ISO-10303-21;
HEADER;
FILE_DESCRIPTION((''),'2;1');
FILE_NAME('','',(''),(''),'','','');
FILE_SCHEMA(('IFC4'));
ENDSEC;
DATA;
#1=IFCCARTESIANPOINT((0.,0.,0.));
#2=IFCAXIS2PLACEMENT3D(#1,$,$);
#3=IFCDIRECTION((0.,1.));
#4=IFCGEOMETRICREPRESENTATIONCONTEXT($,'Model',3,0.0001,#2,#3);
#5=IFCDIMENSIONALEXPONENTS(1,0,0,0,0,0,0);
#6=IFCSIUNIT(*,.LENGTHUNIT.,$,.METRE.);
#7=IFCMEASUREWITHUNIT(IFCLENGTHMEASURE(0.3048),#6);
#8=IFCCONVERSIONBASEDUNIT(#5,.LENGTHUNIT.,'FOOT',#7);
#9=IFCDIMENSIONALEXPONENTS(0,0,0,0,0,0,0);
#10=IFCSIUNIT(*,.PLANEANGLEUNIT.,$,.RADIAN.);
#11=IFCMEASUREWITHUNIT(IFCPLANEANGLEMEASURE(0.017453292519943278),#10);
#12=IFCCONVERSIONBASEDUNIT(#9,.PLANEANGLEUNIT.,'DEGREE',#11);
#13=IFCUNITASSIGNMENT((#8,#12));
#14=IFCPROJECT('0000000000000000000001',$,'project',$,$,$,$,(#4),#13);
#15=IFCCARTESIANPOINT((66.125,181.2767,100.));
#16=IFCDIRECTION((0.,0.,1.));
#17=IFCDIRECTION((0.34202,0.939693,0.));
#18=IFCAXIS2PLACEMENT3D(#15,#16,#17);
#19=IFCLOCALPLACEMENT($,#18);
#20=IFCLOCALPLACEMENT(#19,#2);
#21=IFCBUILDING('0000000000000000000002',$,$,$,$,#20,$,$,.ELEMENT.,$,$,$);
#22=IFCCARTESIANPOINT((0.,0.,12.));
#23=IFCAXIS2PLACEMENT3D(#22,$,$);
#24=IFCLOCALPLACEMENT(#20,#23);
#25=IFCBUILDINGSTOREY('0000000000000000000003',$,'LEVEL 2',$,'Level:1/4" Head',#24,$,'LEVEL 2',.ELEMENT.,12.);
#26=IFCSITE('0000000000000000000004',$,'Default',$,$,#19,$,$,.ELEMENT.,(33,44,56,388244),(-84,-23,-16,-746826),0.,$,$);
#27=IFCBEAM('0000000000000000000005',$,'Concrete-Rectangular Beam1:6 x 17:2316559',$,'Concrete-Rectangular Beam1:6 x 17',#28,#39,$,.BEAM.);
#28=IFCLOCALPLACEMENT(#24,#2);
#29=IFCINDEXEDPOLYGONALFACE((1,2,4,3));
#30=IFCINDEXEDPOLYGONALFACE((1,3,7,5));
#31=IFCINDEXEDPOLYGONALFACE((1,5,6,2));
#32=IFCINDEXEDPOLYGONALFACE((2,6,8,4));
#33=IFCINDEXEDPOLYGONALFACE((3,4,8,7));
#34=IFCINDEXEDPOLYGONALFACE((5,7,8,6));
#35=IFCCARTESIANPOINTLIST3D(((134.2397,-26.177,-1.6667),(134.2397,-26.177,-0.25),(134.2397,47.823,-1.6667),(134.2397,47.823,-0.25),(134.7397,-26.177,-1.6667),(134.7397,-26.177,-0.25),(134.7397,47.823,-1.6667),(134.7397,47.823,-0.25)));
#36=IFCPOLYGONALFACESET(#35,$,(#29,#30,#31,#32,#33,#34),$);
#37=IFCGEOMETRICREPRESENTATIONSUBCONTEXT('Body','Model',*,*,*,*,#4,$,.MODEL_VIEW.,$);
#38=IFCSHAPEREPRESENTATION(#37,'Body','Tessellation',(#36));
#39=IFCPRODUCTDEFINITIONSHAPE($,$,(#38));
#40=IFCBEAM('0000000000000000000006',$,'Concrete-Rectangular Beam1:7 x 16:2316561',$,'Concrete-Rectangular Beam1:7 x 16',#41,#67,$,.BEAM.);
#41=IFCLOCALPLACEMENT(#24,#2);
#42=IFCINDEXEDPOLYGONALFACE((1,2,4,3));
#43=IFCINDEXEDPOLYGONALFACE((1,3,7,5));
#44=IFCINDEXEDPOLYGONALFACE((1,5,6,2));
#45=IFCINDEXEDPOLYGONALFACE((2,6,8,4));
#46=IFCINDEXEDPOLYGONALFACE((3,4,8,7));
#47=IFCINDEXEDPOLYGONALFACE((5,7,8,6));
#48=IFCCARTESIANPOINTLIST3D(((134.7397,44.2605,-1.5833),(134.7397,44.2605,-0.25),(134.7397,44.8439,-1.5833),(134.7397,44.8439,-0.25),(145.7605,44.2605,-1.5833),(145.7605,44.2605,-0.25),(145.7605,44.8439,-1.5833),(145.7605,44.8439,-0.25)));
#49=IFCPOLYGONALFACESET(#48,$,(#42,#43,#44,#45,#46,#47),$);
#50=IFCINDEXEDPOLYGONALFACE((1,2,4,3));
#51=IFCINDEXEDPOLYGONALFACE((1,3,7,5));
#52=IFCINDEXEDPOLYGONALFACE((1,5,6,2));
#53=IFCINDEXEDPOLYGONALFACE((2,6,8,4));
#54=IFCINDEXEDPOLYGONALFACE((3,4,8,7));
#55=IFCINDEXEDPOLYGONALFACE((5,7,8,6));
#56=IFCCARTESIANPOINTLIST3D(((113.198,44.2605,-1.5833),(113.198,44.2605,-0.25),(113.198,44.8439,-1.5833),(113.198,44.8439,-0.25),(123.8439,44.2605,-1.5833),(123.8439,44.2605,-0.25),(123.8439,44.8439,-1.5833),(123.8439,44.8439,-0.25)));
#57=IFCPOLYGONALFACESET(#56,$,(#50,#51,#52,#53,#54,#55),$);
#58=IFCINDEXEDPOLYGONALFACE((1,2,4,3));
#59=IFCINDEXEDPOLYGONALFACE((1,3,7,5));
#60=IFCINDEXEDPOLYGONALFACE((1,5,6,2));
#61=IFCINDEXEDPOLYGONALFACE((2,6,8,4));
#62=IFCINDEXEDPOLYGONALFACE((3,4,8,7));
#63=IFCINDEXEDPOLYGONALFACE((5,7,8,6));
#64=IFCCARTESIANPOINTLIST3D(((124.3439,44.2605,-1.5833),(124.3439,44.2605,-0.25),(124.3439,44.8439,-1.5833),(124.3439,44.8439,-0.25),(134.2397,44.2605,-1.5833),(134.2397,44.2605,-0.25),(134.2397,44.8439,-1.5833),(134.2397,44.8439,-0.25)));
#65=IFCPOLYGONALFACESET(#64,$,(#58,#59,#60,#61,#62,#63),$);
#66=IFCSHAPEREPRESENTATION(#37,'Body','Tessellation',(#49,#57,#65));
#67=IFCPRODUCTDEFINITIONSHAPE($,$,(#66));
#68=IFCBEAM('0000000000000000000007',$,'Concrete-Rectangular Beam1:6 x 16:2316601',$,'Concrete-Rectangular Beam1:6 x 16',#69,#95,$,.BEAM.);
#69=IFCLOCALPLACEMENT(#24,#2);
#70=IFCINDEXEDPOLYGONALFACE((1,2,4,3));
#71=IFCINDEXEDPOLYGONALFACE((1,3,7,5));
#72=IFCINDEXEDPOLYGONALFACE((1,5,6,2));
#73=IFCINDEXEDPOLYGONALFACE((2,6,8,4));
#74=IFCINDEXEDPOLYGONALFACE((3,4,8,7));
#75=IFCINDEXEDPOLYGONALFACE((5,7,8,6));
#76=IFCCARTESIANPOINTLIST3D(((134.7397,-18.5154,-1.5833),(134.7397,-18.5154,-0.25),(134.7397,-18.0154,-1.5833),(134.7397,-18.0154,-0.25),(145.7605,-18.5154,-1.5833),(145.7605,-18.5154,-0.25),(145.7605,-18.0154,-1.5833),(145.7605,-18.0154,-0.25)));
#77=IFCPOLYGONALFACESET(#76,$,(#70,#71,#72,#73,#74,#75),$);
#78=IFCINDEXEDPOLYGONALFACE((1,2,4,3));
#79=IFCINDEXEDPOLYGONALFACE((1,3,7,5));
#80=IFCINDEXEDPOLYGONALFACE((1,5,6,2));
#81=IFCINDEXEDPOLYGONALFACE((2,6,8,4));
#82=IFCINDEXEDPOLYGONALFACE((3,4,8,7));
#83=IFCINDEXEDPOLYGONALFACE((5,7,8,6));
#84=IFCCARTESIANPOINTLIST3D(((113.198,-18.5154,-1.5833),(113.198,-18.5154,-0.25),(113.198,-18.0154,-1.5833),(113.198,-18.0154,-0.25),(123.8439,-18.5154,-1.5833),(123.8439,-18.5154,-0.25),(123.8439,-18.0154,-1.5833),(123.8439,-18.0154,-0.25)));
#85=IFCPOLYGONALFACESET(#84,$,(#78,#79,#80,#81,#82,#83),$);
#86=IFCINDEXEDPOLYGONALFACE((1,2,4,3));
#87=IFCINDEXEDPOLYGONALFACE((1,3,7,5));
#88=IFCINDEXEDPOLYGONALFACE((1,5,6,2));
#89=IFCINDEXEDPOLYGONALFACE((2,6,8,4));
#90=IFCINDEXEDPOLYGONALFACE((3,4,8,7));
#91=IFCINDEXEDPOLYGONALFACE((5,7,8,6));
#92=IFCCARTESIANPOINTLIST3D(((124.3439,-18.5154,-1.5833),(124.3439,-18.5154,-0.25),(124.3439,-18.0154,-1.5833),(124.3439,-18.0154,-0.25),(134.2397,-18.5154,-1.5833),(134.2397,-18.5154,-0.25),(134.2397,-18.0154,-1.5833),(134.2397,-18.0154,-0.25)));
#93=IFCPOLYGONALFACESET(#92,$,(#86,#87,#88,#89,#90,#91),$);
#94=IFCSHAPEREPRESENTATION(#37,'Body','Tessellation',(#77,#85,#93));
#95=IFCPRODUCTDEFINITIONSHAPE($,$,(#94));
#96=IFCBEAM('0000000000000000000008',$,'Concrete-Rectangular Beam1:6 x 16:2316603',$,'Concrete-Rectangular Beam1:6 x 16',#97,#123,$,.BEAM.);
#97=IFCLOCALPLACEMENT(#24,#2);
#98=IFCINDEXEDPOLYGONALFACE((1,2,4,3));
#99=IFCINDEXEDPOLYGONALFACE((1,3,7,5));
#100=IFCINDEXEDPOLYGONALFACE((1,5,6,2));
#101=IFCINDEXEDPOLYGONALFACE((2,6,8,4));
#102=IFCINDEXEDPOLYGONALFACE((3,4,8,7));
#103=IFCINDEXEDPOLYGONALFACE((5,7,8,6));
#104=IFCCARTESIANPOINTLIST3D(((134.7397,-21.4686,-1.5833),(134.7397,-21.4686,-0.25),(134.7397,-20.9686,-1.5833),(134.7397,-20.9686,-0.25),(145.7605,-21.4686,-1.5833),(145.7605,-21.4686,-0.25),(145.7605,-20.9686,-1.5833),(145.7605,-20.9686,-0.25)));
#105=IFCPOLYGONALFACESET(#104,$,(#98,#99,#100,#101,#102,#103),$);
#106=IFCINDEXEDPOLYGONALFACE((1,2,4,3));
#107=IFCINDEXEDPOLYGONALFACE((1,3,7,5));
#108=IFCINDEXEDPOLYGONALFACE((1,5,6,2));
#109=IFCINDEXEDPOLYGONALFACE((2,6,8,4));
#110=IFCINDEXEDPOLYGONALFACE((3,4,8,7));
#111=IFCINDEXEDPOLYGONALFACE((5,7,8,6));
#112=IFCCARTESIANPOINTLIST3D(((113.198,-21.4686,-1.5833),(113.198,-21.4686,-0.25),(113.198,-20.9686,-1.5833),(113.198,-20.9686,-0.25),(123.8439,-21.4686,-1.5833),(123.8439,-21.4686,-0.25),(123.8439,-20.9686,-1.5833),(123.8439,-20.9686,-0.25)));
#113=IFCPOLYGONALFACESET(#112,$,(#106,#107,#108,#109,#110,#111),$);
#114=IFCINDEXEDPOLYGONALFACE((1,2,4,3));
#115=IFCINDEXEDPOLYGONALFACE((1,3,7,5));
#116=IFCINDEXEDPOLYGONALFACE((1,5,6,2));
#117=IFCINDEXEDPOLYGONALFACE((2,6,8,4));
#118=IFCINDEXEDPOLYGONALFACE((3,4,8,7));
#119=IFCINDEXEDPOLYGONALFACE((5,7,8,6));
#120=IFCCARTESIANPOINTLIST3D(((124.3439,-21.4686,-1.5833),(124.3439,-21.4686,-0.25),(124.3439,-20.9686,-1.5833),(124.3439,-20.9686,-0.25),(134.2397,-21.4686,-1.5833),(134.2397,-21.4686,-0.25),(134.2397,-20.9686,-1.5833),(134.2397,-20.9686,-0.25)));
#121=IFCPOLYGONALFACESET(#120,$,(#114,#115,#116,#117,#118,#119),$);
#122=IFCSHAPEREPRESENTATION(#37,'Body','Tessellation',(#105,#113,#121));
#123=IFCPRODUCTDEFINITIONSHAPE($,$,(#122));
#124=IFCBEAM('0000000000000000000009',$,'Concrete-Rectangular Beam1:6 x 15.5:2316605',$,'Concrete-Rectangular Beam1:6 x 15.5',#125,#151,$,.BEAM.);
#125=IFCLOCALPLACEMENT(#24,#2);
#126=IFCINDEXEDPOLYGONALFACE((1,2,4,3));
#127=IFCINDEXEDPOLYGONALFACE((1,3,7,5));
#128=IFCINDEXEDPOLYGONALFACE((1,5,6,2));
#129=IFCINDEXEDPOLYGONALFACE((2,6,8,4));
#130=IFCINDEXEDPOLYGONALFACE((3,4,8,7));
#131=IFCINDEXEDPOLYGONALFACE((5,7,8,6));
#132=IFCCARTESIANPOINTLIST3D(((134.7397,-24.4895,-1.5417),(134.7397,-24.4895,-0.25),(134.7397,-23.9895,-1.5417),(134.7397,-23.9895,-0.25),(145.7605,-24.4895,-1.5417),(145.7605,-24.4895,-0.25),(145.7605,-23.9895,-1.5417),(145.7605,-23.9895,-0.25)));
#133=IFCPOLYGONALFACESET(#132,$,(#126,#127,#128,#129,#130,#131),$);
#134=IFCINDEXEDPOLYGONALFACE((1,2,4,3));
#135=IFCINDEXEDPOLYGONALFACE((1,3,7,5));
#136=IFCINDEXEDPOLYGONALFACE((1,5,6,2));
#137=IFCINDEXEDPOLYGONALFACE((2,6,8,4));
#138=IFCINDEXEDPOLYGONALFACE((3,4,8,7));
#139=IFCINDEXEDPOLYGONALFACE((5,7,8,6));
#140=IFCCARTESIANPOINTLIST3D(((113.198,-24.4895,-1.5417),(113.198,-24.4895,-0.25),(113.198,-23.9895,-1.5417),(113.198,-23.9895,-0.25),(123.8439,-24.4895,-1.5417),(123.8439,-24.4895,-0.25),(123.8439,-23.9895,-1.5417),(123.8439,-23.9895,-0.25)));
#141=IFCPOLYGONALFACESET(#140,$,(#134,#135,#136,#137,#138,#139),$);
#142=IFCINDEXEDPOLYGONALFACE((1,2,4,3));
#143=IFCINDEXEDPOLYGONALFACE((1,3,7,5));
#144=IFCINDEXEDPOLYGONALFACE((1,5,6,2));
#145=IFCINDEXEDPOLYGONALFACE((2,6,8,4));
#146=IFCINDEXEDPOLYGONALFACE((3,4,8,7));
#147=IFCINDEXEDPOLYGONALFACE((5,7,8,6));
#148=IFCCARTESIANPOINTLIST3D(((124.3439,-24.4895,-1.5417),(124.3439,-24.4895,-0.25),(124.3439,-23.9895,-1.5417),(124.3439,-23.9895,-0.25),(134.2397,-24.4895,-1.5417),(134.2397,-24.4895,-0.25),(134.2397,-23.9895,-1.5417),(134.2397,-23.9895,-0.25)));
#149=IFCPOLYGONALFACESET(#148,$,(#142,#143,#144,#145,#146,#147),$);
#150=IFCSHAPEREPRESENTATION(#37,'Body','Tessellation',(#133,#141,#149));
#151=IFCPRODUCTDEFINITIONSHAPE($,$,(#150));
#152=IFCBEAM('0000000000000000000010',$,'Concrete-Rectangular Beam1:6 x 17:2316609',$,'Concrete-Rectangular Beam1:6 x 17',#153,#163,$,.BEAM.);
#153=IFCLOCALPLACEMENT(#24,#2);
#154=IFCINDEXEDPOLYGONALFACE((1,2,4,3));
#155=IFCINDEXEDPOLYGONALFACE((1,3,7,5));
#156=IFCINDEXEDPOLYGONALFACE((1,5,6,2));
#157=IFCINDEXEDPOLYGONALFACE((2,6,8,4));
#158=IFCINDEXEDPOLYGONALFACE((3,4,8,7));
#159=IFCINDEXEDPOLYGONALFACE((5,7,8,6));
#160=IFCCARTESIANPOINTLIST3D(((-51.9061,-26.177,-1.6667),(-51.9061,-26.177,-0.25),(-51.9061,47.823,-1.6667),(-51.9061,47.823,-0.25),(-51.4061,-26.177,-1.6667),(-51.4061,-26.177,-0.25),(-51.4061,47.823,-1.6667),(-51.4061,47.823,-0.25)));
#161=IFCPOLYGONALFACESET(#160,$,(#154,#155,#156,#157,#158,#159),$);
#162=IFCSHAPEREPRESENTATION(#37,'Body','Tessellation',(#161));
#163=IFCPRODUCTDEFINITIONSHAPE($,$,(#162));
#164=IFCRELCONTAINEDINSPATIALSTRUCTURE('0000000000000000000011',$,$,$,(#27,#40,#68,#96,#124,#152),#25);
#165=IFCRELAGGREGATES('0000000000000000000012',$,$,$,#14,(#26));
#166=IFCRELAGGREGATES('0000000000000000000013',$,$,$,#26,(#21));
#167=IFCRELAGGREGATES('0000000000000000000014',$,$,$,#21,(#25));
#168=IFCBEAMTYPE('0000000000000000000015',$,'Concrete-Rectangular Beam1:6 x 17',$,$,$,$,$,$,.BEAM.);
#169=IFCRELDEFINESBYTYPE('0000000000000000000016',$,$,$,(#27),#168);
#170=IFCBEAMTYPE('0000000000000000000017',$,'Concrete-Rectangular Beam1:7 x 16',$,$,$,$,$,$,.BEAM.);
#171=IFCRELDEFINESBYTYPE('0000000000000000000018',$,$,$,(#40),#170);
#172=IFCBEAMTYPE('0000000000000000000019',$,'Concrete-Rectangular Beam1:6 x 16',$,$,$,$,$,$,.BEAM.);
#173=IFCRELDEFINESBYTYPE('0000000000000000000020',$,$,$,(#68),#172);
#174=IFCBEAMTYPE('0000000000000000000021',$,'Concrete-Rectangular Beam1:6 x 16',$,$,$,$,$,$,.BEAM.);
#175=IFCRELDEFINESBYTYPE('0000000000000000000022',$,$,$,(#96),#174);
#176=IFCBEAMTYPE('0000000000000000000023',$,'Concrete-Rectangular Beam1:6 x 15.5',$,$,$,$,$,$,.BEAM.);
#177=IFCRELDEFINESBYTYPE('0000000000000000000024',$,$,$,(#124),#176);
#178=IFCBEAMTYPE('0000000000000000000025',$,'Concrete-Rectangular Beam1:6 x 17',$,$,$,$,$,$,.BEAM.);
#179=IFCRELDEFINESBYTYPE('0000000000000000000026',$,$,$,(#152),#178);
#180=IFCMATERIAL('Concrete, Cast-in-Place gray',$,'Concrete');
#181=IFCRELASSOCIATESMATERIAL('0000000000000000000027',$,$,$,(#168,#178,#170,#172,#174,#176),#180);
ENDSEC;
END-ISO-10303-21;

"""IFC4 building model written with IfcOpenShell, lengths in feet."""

from ifc_helpers import new_model, entity, si_unit, converted_unit, direction, frame, frame_2d, origin, origin_2d_with_axis, place, context, subcontext, project, spatial, polyline, segment, composite_curve, rectangle, outline, extrude, source, transform, mapped, material, material_profile, profile_set, type_object, type_shapes, element, save


model = new_model("IFC4")

# Units and contexts
model_context = context("Model", 3, precision=0.0001, world=origin(), true_north=direction((0.0, 1.0)))
body_context = subcontext(model_context, "Body", "Model", "MODEL_VIEW")
ifc_project = project(units=[converted_unit("LENGTHUNIT", "FOOT", entity("IfcLengthMeasure", 0.3048), si_unit("LENGTHUNIT", "METRE"), dimensions=[1, 0, 0, 0, 0, 0, 0]), converted_unit("PLANEANGLEUNIT", "DEGREE", entity("IfcPlaneAngleMeasure", 0.017453292519943278), si_unit("PLANEANGLEUNIT", "RADIAN"), dimensions=[0, 0, 0, 0, 0, 0, 0])], contexts=[model_context])

# Site, building, storey
site_placement = place(None, frame((66.125, 181.2767, 100.0), z_axis=(0.0, 0.0, 1.0), x_axis=(0.34202, 0.939693, 0.0)))
site = spatial("IfcSite", under=ifc_project, at=site_placement, Name="Default", CompositionType="ELEMENT", RefLatitude=(33, 44, 56, 388244), RefLongitude=(-84, -23, -16, -746826), RefElevation=0.0)
building_placement = place(site_placement, origin())
building = spatial("IfcBuilding", under=site, at=building_placement, CompositionType="ELEMENT")
storey_placement = place(building_placement, frame((0.0, 0.0, 12.0)))
storey = spatial("IfcBuildingStorey", under=building, at=storey_placement, Name="LEVEL 2", ObjectType="Level:1/4\" Head", LongName="LEVEL 2", CompositionType="ELEMENT", Elevation=12.0)

# Beams
ifc_material = material(Name="Concrete, Cast-in-Place gray", Category="Concrete")
ifc_material_profile_1 = material_profile(ifc_material, rectangle(XDim=1.4167, YDim=0.5, at=frame_2d((0.0, 0.0), x_axis=(0.0, 1.0))), Name="6 x 17")
ifc_profile_set_1 = profile_set([ifc_material_profile_1], Name="6 x 17")
beam_type_1 = type_object("IfcBeamType", Name="Concrete-Rectangular Beam1:6 x 17", PredefinedType="BEAM", material=ifc_profile_set_1)
shared_shape_1 = source(origin(), body_context, "Body", "SweptSolid", [
    extrude(rectangle(XDim=1.4167, YDim=0.5, at=frame_2d((0.0, 0.0), x_axis=(0.0, 1.0))), frame((134.4897, 47.823, 11.0417), z_axis=(0.0, -1.0, 0.0), x_axis=(-1.0, 0.0, 0.0)), (0.0, 0.0, 1.0), 74.0),
])
type_shapes(beam_type_1, [shared_shape_1])
beam_1_placement = place(storey_placement, frame((0.0, 0.0, -12.0)))
element("IfcBeam", 1, at=beam_1_placement, inside=storey, type_object=beam_type_1, Name="Concrete-Rectangular Beam1:6 x 17:2316559", ObjectType="Concrete-Rectangular Beam1:6 x 17", PredefinedType="BEAM", context=body_context, shape_type="MappedRepresentation", body=[
    mapped(shared_shape_1, transform((0.0, 0.0, 0.0), scale=1.0)),
])
ifc_material_profile_2 = material_profile(ifc_material, rectangle(XDim=1.3333, YDim=0.5833, at=frame_2d((0.0, 0.0), x_axis=(1.0, 0.0))), Name="7 x 16")
ifc_profile_set_2 = profile_set([ifc_material_profile_2], Name="7 x 16")
beam_type_2 = type_object("IfcBeamType", Name="Concrete-Rectangular Beam1:7 x 16", PredefinedType="BEAM", material=ifc_profile_set_2)
shared_shape_2 = source(origin(), body_context, "Body", "SweptSolid", [
    extrude(rectangle(XDim=1.3333, YDim=0.5833, at=origin_2d_with_axis()), frame((134.7397, 44.5522, 11.0833), z_axis=(1.0, 0.0, 0.0), x_axis=(0.0, 0.0, -1.0)), (0.0, 0.0, 1.0), 11.0208),
    extrude(rectangle(XDim=1.3333, YDim=0.5833, at=origin_2d_with_axis()), frame((113.198, 44.5522, 11.0833), z_axis=(1.0, 0.0, 0.0), x_axis=(0.0, 0.0, -1.0)), (0.0, 0.0, 1.0), 10.6458),
    extrude(rectangle(XDim=1.3333, YDim=0.5833, at=origin_2d_with_axis()), frame((124.3439, 44.5522, 11.0833), z_axis=(1.0, 0.0, 0.0), x_axis=(0.0, 0.0, -1.0)), (0.0, 0.0, 1.0), 9.8958),
])
type_shapes(beam_type_2, [shared_shape_2])
beam_2_placement = place(storey_placement, frame((0.0, 0.0, -12.0)))
element("IfcBeam", 2, at=beam_2_placement, inside=storey, type_object=beam_type_2, Name="Concrete-Rectangular Beam1:7 x 16:2316561", ObjectType="Concrete-Rectangular Beam1:7 x 16", PredefinedType="BEAM", context=body_context, shape_type="MappedRepresentation", body=[
    mapped(shared_shape_2, transform((0.0, 0.0, 0.0), scale=1.0)),
])
ifc_material_profile_3 = material_profile(ifc_material, rectangle(XDim=1.3333, YDim=0.5, at=frame_2d((0.0, 0.0), x_axis=(1.0, 0.0))), Name="6 x 16")
ifc_profile_set_3 = profile_set([ifc_material_profile_3], Name="6 x 16")
beam_type_3 = type_object("IfcBeamType", Name="Concrete-Rectangular Beam1:6 x 16", PredefinedType="BEAM", material=ifc_profile_set_3)
shared_shape_3 = source(origin(), body_context, "Body", "SweptSolid", [
    extrude(rectangle(XDim=1.3333, YDim=0.5, at=frame_2d((0.0, 0.0), x_axis=(1.0, 0.0))), frame((134.7397, -18.2654, 11.0833), z_axis=(1.0, 0.0, 0.0), x_axis=(0.0, 0.0, -1.0)), (0.0, 0.0, 1.0), 11.0208),
    extrude(rectangle(XDim=1.3333, YDim=0.5, at=frame_2d((0.0, 0.0), x_axis=(1.0, 0.0))), frame((113.198, -18.2654, 11.0833), z_axis=(1.0, 0.0, 0.0), x_axis=(0.0, 0.0, -1.0)), (0.0, 0.0, 1.0), 10.6458),
    extrude(rectangle(XDim=1.3333, YDim=0.5, at=frame_2d((0.0, 0.0), x_axis=(1.0, 0.0))), frame((124.3439, -18.2654, 11.0833), z_axis=(1.0, 0.0, 0.0), x_axis=(0.0, 0.0, -1.0)), (0.0, 0.0, 1.0), 9.8958),
])
type_shapes(beam_type_3, [shared_shape_3])
beam_3_placement = place(storey_placement, frame((0.0, 0.0, -12.0)))
element("IfcBeam", 3, at=beam_3_placement, inside=storey, type_object=beam_type_3, Name="Concrete-Rectangular Beam1:6 x 16:2316601", ObjectType="Concrete-Rectangular Beam1:6 x 16", PredefinedType="BEAM", context=body_context, shape_type="MappedRepresentation", body=[
    mapped(shared_shape_3, transform((0.0, 0.0, 0.0), scale=1.0)),
])
beam_type_4 = type_object("IfcBeamType", Name="Concrete-Rectangular Beam1:6 x 16", PredefinedType="BEAM", material=ifc_profile_set_3)
shared_shape_4 = source(origin(), body_context, "Body", "SweptSolid", [
    extrude(rectangle(XDim=1.3333, YDim=0.5, at=frame_2d((0.0, 0.0), x_axis=(1.0, 0.0))), frame((134.7397, -21.2186, 11.0833), z_axis=(1.0, 0.0, 0.0), x_axis=(0.0, 0.0, -1.0)), (0.0, 0.0, 1.0), 11.0208),
    extrude(rectangle(XDim=1.3333, YDim=0.5, at=frame_2d((0.0, 0.0), x_axis=(1.0, 0.0))), frame((113.198, -21.2186, 11.0833), z_axis=(1.0, 0.0, 0.0), x_axis=(0.0, 0.0, -1.0)), (0.0, 0.0, 1.0), 10.6458),
    extrude(rectangle(XDim=1.3333, YDim=0.5, at=frame_2d((0.0, 0.0), x_axis=(1.0, 0.0))), frame((124.3439, -21.2186, 11.0833), z_axis=(1.0, 0.0, 0.0), x_axis=(0.0, 0.0, -1.0)), (0.0, 0.0, 1.0), 9.8958),
])
type_shapes(beam_type_4, [shared_shape_4])
beam_4_placement = place(storey_placement, frame((0.0, 0.0, -12.0)))
element("IfcBeam", 4, at=beam_4_placement, inside=storey, type_object=beam_type_4, Name="Concrete-Rectangular Beam1:6 x 16:2316603", ObjectType="Concrete-Rectangular Beam1:6 x 16", PredefinedType="BEAM", context=body_context, shape_type="MappedRepresentation", body=[
    mapped(shared_shape_4, transform((0.0, 0.0, 0.0), scale=1.0)),
])
ifc_material_profile_4 = material_profile(ifc_material, outline(composite_curve([segment(polyline([(-0.25, 0.6458, 0.0), (0.25, 0.6458, 0.0)]), True, "CONTINUOUS"), segment(polyline([(0.25, 0.6458, 0.0), (0.25, -0.6458, 0.0)]), True, "CONTINUOUS"), segment(polyline([(0.25, -0.6458, 0.0), (-0.25, -0.6458, 0.0)]), True, "CONTINUOUS"), segment(polyline([(-0.25, -0.6458, 0.0), (-0.25, 0.6458, 0.0)]), True, "CONTINUOUS")], self_intersect=False), kind="CURVE"), Name="6 x 15.5")
ifc_material_profile_5 = material_profile(ifc_material, outline(composite_curve([segment(polyline([(-12.5417, 0.25, 0.6458), (-12.5417, 0.25, -0.6458)]), True, "CONTINUOUS"), segment(polyline([(-12.5417, 0.25, -0.6458), (-12.5417, -0.25, -0.6458)]), True, "CONTINUOUS"), segment(polyline([(-12.5417, -0.25, -0.6458), (-12.5417, -0.25, 0.6458)]), True, "CONTINUOUS"), segment(polyline([(-12.5417, -0.25, 0.6458), (-12.5417, 0.25, 0.6458)]), True, "CONTINUOUS")], self_intersect=False), kind="CURVE"), Name="6 x 15.5")
ifc_profile_set_4 = profile_set([ifc_material_profile_4, ifc_material_profile_5], Name="6 x 15.5")
beam_type_5 = type_object("IfcBeamType", Name="Concrete-Rectangular Beam1:6 x 15.5", PredefinedType="BEAM", material=ifc_profile_set_4)
shared_shape_5 = source(origin(), body_context, "Body", "SweptSolid", [
    extrude(rectangle(XDim=1.2917, YDim=0.5, at=frame_2d((0.0, 0.0), x_axis=(1.0, 0.0))), frame((134.7397, -24.2395, 11.1042), z_axis=(1.0, 0.0, 0.0), x_axis=(0.0, 0.0, -1.0)), (0.0, 0.0, 1.0), 11.0208),
    extrude(rectangle(XDim=1.2917, YDim=0.5, at=frame_2d((0.0, 0.0), x_axis=(1.0, 0.0))), frame((113.198, -24.2395, 11.1042), z_axis=(1.0, 0.0, 0.0), x_axis=(0.0, 0.0, -1.0)), (0.0, 0.0, 1.0), 10.6458),
    extrude(rectangle(XDim=1.2917, YDim=0.5, at=frame_2d((0.0, 0.0), x_axis=(1.0, 0.0))), frame((124.3439, -24.2395, 11.1042), z_axis=(1.0, 0.0, 0.0), x_axis=(0.0, 0.0, -1.0)), (0.0, 0.0, 1.0), 9.8958),
])
type_shapes(beam_type_5, [shared_shape_5])
beam_5_placement = place(storey_placement, frame((0.0, 0.0, -12.0)))
element("IfcBeam", 5, at=beam_5_placement, inside=storey, type_object=beam_type_5, Name="Concrete-Rectangular Beam1:6 x 15.5:2316605", ObjectType="Concrete-Rectangular Beam1:6 x 15.5", PredefinedType="BEAM", context=body_context, shape_type="MappedRepresentation", body=[
    mapped(shared_shape_5, transform((0.0, 0.0, 0.0), scale=1.0)),
])
beam_type_6 = type_object("IfcBeamType", Name="Concrete-Rectangular Beam1:6 x 17", PredefinedType="BEAM", material=ifc_profile_set_1)
shared_shape_6 = source(origin(), body_context, "Body", "SweptSolid", [
    extrude(rectangle(XDim=1.4167, YDim=0.5, at=frame_2d((0.0, 0.0), x_axis=(0.0, 1.0))), frame((-51.6561, 47.823, 11.0417), z_axis=(0.0, -1.0, 0.0), x_axis=(-1.0, 0.0, 0.0)), (0.0, 0.0, 1.0), 74.0),
])
type_shapes(beam_type_6, [shared_shape_6])
beam_6_placement = place(storey_placement, frame((0.0, 0.0, -12.0)))
element("IfcBeam", 6, at=beam_6_placement, inside=storey, type_object=beam_type_6, Name="Concrete-Rectangular Beam1:6 x 17:2316609", ObjectType="Concrete-Rectangular Beam1:6 x 17", PredefinedType="BEAM", context=body_context, shape_type="MappedRepresentation", body=[
    mapped(shared_shape_6, transform((0.0, 0.0, 0.0), scale=1.0)),
])

save(model, "model.ifc")
